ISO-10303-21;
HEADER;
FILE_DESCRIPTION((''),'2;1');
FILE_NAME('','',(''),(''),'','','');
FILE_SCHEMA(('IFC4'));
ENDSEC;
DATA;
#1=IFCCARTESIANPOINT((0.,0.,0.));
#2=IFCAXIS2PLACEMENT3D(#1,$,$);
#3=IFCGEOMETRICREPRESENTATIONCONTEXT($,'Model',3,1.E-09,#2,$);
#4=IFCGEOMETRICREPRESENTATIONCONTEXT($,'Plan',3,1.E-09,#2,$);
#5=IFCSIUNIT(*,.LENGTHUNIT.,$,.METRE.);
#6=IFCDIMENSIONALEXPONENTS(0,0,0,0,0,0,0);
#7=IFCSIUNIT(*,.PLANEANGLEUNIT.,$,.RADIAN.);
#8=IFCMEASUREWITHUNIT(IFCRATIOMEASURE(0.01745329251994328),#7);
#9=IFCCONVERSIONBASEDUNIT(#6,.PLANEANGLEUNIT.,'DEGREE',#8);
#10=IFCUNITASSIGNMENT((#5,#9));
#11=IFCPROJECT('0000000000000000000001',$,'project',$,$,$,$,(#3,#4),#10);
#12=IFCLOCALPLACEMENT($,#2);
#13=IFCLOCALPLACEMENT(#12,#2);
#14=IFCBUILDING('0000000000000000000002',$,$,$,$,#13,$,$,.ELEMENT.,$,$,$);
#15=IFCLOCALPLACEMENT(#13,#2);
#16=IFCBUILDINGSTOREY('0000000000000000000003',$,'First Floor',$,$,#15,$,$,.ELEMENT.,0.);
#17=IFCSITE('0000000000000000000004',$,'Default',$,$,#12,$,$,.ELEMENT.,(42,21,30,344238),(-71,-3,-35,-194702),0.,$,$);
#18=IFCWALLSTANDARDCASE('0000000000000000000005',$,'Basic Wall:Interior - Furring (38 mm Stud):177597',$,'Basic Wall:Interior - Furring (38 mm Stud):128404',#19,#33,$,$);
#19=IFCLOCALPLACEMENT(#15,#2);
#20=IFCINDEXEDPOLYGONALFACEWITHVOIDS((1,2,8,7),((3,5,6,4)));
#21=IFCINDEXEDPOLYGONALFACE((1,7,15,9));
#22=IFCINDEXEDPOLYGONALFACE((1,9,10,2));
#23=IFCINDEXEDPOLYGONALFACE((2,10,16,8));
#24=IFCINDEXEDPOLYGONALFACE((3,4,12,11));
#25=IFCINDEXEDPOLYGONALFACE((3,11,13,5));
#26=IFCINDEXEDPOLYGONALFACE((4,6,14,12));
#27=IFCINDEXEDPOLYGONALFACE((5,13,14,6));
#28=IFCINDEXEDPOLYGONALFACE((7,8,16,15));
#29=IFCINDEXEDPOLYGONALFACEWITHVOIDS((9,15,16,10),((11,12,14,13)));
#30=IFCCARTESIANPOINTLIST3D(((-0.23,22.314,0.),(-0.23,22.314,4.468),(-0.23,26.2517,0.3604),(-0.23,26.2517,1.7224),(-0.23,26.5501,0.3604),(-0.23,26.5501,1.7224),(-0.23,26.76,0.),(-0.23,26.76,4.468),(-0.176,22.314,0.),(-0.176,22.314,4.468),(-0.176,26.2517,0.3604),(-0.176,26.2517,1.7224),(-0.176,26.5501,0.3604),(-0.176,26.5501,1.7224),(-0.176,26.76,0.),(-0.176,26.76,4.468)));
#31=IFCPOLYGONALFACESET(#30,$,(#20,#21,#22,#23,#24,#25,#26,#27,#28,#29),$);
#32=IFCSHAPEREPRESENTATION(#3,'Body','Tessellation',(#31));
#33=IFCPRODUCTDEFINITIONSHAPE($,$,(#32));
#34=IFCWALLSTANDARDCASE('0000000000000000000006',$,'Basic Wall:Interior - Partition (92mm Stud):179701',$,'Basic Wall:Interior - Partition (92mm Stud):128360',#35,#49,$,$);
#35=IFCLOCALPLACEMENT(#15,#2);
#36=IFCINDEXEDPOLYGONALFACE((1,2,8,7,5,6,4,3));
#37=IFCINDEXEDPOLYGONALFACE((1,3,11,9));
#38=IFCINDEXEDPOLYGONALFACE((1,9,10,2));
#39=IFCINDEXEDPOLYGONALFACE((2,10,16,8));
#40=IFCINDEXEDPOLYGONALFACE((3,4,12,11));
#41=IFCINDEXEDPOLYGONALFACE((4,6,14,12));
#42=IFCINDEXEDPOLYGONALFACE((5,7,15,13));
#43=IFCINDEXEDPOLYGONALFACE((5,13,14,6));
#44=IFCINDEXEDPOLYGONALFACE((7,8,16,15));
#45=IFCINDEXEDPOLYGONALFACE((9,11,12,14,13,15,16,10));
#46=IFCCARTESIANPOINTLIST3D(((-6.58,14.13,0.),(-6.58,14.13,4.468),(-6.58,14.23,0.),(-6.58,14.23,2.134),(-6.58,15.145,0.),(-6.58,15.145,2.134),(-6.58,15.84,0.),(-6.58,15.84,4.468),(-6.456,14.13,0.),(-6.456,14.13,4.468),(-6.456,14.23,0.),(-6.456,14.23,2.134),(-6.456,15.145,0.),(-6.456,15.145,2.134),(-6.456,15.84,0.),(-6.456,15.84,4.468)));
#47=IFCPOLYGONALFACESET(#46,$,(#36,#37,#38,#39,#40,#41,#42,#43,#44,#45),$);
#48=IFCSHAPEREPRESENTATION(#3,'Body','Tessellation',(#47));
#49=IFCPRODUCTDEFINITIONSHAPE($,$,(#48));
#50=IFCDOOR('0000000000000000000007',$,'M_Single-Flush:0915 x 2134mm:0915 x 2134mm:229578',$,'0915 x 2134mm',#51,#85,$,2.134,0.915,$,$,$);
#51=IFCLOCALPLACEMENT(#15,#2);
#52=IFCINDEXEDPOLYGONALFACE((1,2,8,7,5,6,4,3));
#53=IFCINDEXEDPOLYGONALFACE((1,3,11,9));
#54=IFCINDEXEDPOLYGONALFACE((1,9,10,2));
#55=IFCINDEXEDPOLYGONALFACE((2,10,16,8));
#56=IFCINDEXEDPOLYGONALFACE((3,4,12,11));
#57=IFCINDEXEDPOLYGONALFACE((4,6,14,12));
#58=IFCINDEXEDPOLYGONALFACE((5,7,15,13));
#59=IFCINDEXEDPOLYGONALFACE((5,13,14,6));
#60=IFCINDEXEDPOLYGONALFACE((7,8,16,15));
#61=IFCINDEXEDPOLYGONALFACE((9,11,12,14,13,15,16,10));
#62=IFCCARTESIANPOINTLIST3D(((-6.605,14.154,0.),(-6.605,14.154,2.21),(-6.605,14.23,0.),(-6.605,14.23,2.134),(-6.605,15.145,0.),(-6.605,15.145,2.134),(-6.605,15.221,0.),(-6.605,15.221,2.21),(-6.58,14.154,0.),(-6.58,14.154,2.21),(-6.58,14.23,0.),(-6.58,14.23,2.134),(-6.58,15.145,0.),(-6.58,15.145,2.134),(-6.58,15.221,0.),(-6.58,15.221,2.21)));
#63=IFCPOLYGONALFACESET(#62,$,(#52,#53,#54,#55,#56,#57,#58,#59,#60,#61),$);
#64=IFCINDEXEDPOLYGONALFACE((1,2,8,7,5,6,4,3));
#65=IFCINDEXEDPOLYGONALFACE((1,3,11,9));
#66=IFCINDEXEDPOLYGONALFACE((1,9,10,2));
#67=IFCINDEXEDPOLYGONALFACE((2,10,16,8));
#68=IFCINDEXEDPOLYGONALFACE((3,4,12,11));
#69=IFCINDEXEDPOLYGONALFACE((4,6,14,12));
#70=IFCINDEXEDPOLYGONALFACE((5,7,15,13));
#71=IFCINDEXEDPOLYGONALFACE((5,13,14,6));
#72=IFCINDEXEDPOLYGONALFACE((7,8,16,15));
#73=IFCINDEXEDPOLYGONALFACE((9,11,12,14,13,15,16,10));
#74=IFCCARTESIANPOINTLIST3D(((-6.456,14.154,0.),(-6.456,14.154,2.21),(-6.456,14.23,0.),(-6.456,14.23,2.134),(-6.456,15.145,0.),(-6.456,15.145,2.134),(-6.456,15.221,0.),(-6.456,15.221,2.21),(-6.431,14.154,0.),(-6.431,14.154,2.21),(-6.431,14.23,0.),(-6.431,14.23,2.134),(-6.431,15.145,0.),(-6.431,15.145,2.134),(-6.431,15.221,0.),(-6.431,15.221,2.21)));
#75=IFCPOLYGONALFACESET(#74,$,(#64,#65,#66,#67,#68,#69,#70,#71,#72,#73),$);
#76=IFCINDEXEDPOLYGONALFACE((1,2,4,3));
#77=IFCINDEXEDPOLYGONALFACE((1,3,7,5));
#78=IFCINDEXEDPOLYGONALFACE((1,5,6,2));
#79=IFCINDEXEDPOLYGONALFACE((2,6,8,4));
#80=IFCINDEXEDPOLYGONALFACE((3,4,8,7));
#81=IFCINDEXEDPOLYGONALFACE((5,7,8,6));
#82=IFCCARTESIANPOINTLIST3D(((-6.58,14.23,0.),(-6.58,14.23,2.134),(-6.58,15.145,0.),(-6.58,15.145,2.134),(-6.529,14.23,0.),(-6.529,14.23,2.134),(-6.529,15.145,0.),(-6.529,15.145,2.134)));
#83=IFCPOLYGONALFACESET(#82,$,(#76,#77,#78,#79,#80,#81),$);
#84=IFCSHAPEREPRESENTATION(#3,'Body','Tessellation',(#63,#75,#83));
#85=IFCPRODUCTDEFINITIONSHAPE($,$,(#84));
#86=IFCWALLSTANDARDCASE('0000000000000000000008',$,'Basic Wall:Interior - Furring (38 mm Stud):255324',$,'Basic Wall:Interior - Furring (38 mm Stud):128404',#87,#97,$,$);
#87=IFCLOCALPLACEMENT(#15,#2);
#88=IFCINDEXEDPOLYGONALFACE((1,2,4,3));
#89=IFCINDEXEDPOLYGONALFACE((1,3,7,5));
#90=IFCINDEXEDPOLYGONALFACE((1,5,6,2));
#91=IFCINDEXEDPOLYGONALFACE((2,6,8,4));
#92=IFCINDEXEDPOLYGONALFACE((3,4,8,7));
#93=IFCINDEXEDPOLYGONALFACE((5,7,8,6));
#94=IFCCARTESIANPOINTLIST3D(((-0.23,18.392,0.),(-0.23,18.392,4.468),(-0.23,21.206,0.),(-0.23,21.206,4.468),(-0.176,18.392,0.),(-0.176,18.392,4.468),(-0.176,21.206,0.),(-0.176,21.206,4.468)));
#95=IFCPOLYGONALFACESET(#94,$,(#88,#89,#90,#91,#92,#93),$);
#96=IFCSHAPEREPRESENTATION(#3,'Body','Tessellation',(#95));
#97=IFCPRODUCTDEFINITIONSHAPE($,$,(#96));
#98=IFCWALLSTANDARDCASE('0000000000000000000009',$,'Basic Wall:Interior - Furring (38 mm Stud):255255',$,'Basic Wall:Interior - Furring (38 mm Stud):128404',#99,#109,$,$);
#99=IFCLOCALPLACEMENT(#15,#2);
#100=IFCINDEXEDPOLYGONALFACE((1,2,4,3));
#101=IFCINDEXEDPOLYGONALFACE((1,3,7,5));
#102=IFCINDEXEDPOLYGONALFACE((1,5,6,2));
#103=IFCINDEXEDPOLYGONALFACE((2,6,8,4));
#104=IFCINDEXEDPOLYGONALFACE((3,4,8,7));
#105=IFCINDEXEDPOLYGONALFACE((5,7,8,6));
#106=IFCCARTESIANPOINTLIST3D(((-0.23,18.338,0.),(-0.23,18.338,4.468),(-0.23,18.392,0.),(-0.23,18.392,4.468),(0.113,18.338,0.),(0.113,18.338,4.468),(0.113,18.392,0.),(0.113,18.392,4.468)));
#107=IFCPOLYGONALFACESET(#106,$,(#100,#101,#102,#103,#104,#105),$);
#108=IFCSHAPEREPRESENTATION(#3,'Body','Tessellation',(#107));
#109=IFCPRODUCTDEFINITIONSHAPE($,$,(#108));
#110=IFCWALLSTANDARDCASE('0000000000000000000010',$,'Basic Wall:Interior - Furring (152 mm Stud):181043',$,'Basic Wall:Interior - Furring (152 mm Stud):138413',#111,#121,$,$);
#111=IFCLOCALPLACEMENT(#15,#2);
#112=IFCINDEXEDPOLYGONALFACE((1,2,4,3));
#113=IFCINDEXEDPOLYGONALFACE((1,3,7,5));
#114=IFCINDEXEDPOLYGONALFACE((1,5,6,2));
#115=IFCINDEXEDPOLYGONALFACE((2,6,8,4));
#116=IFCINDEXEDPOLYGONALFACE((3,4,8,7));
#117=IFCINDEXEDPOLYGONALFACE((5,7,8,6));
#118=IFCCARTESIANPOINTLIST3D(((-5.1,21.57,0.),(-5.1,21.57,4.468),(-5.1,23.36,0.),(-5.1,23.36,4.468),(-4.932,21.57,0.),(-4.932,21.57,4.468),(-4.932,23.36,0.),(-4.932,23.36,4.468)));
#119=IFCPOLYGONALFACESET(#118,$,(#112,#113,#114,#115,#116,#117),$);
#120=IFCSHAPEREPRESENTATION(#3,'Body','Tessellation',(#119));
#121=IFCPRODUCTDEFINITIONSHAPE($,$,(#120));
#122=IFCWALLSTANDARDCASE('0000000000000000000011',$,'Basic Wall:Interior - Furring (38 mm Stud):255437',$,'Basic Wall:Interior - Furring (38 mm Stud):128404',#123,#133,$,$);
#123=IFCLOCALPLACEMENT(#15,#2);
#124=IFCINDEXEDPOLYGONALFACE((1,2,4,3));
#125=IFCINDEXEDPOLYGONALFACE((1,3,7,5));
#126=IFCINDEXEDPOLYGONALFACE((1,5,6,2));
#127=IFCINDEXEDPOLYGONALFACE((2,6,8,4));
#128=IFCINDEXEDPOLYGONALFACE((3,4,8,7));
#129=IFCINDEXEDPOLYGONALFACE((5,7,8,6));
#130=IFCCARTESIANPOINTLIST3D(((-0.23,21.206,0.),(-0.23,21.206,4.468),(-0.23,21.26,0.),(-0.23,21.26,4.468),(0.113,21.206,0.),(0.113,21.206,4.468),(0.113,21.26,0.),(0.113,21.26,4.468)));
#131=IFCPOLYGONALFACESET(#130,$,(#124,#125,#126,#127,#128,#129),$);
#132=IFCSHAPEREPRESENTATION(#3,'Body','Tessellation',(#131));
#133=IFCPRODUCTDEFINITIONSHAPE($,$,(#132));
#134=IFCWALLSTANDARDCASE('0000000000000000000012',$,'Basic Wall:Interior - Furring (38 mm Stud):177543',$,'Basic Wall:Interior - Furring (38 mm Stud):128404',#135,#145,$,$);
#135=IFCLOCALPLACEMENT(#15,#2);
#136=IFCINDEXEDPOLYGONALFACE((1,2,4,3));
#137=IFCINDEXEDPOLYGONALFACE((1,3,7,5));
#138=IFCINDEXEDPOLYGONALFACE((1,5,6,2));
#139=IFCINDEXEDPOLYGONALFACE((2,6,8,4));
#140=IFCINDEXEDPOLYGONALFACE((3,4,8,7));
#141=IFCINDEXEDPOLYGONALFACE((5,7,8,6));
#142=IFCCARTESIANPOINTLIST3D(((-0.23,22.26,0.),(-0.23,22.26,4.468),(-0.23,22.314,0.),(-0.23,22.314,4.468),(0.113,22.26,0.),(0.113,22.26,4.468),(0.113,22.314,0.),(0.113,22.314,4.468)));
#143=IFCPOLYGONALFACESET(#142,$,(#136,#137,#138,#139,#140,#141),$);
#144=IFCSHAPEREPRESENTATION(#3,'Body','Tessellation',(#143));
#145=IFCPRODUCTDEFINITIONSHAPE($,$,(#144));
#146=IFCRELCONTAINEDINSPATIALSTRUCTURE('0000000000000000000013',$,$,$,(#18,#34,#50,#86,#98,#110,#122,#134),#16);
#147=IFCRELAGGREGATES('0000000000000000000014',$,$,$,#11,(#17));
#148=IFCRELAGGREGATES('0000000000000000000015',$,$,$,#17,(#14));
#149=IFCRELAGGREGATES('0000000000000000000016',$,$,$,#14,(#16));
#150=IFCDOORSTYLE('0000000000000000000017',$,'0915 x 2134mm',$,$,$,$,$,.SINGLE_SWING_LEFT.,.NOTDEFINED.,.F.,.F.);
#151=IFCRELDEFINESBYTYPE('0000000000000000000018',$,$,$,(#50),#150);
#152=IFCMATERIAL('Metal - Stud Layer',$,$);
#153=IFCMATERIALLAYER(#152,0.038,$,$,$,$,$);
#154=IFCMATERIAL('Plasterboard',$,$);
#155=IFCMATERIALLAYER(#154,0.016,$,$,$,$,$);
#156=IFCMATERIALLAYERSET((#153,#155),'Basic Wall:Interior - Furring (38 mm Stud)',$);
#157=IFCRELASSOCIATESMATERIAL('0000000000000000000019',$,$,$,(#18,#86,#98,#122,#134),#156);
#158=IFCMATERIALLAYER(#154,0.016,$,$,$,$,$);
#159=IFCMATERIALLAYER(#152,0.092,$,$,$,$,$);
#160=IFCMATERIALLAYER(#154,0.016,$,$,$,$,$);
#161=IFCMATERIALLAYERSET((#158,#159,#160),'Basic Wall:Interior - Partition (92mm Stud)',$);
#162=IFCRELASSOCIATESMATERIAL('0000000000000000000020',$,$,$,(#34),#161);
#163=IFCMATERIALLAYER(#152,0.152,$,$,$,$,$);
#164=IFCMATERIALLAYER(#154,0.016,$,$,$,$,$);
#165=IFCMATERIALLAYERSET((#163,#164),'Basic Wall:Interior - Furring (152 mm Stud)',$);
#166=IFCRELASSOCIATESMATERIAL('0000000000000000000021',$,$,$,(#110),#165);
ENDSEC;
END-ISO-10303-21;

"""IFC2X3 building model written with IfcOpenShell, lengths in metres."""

from ifc_helpers import new_model, entity, si_unit, converted_unit, frame, frame_2d, origin, origin_2d_with_axis, place, context, project, spatial, polyline, rectangle, outline, extrude, source, transform, mapped, material, layer, layer_set, layer_usage, type_object, type_shapes, element, fill, save


model = new_model("IFC2X3")

# Units and contexts
model_context = context("Model", 3, precision=1e-09, world=origin())
plan_context = context("Plan", 3, precision=1e-09, world=origin())
ifc_project = project(units=[si_unit("LENGTHUNIT", "METRE"), converted_unit("PLANEANGLEUNIT", "DEGREE", entity("IfcRatioMeasure", 0.01745329251994328), si_unit("PLANEANGLEUNIT", "RADIAN"), dimensions=[0, 0, 0, 0, 0, 0, 0])], contexts=[model_context, plan_context])

# Site, building, storey
site_placement = place(None, origin())
site = spatial("IfcSite", under=ifc_project, at=site_placement, Name="Default", CompositionType="ELEMENT", RefLatitude=(42, 21, 30, 344238), RefLongitude=(-71, -3, -35, -194702), RefElevation=0.0)
building_placement = place(site_placement, origin())
building = spatial("IfcBuilding", under=site, at=building_placement, CompositionType="ELEMENT")
storey_placement = place(building_placement, origin())
storey = spatial("IfcBuildingStorey", under=building, at=storey_placement, Name="First Floor", CompositionType="ELEMENT", Elevation=0.0)

# Shared definitions
ifc_material_1 = material(Name="Plasterboard")
ifc_layer_1 = layer(ifc_material_1, 0.016)
ifc_material_2 = material(Name="Metal - Stud Layer")
ifc_layer_2 = layer(ifc_material_2, 0.092)
ifc_layer_3 = layer(ifc_material_1, 0.016)
ifc_layer_set_1 = layer_set([ifc_layer_1, ifc_layer_2, ifc_layer_3], Name="Basic Wall:Interior - Partition (92mm Stud)")
ifc_layer_usage_1 = layer_usage(ifc_layer_set_1, "AXIS2", "NEGATIVE", 0.062)

# Shared definitions
door_style_1 = type_object("IfcDoorStyle", Name="0915 x 2134mm", ConstructionType="NOTDEFINED", OperationType="SINGLE_SWING_LEFT", ParameterTakesPrecedence=False, Sizeable=False)
shared_shape_1 = source(origin(), model_context, "Body", "SweptSolid", [
    extrude(outline(polyline([(-0.5335, -1.124), (0.5335, -1.124), (0.5335, 1.086), (0.4575, 1.086), (0.4575, -1.048), (-0.4575, -1.048), (-0.4575, 1.086), (-0.5335, 1.086), (-0.5335, -1.124)])), frame((0.4575, 0.149, 1.086), z_axis=(0.0, -1.0, 0.0), x_axis=(-1.0, 0.0, 0.0)), (0.0, 0.0, 1.0), 0.025),
    extrude(outline(polyline([(-1.124, -0.5335), (1.086, -0.5335), (1.086, -0.4575), (-1.048, -0.4575), (-1.048, 0.4575), (1.086, 0.4575), (1.086, 0.5335), (-1.124, 0.5335), (-1.124, -0.5335)])), frame((0.4575, 0.0, 1.086), z_axis=(0.0, -1.0, 0.0), x_axis=(0.0, 0.0, -1.0)), (0.0, 0.0, 1.0), 0.025),
    extrude(rectangle(XDim=0.915, YDim=0.051, at=origin_2d_with_axis()), frame((0.4575, 0.0985, 0.0)), (0.0, 0.0, 1.0), 2.134),
])
type_shapes(door_style_1, [shared_shape_1])

# Wall, opening
ifc_layer_4 = layer(ifc_material_2, 0.038)
ifc_layer_5 = layer(ifc_material_1, 0.016)
ifc_layer_set_2 = layer_set([ifc_layer_4, ifc_layer_5], Name="Basic Wall:Interior - Furring (38 mm Stud)")
ifc_layer_usage_2 = layer_usage(ifc_layer_set_2, "AXIS2", "POSITIVE", -0.027)
wall_1_placement = place(storey_placement, frame((-0.203, 22.314, 0.0), z_axis=(0.0, 0.0, 1.0), x_axis=(0.0, 1.0, 0.0)))
wall_1 = element("IfcWallStandardCase", 1, at=wall_1_placement, inside=storey, material=ifc_layer_usage_2, Name="Basic Wall:Interior - Furring (38 mm Stud):177597", ObjectType="Basic Wall:Interior - Furring (38 mm Stud):128404", context=model_context, shape_type="SweptSolid", body=[
    extrude(rectangle(XDim=4.446, YDim=0.054, at=frame_2d((2.223, 0.0), x_axis=(-1.0, 0.0))), origin(), (0.0, 0.0, 1.0), 4.468),
])
opening_1_placement = place(wall_1_placement, origin())
element("IfcOpeningElement", 2, at=opening_1_placement, cuts=wall_1, ObjectType="Opening", context=model_context, shape_type="SweptSolid", body=[
    extrude(rectangle(XDim=1.3621, YDim=0.2985, at=frame_2d((0.0, 0.0), x_axis=(0.0, 1.0))), frame((4.0869, -0.0619, 1.0414), z_axis=(0.0, 1.0, 0.0), x_axis=(1.0, 0.0, 0.0)), (0.0, 0.0, 1.0), 0.1524),
])

# Wall, opening, door
wall_2_placement = place(storey_placement, frame((-6.518, 14.13, 0.0), z_axis=(0.0, 0.0, 1.0), x_axis=(0.0, 1.0, 0.0)))
wall_2 = element("IfcWallStandardCase", 3, at=wall_2_placement, inside=storey, material=ifc_layer_usage_1, Name="Basic Wall:Interior - Partition (92mm Stud):179701", ObjectType="Basic Wall:Interior - Partition (92mm Stud):128360", context=model_context, shape_type="SweptSolid", body=[
    extrude(rectangle(XDim=1.71, YDim=0.124, at=frame_2d((0.855, 0.0), x_axis=(-1.0, 0.0))), origin(), (0.0, 0.0, 1.0), 4.468),
])
opening_2_placement = place(wall_2_placement, frame((0.1, -0.062, 0.0)))
opening_2 = element("IfcOpeningElement", 4, at=opening_2_placement, cuts=wall_2, ObjectType="Opening", context=model_context, shape_type="SweptSolid", body=[
    extrude(rectangle(XDim=0.915, YDim=2.134, at=frame_2d((1.067, 0.4575), x_axis=(0.0, -1.0))), frame((0.0, 0.0, 0.0), z_axis=(0.0, 1.0, 0.0), x_axis=(0.0, 0.0, 1.0)), (0.0, 0.0, 1.0), 0.124),
])
door_1_placement = place(opening_2_placement, origin())
door_1 = element("IfcDoor", 5, at=door_1_placement, inside=storey, type_object=door_style_1, Name="M_Single-Flush:0915 x 2134mm:0915 x 2134mm:229578", ObjectType="0915 x 2134mm", OverallHeight=2.134, OverallWidth=0.915, context=model_context, shape_type="MappedRepresentation", body=[
    mapped(shared_shape_1, transform((0.0, 0.0, 0.0), scale=1.0)),
])
fill(opening_2, door_1)

# Walls
wall_3_placement = place(storey_placement, frame((-0.203, 18.392, 0.0), z_axis=(0.0, 0.0, 1.0), x_axis=(0.0, 1.0, 0.0)))
element("IfcWallStandardCase", 6, at=wall_3_placement, inside=storey, material=ifc_layer_usage_2, Name="Basic Wall:Interior - Furring (38 mm Stud):255324", ObjectType="Basic Wall:Interior - Furring (38 mm Stud):128404", context=model_context, shape_type="SweptSolid", body=[
    extrude(rectangle(XDim=2.814, YDim=0.054, at=frame_2d((1.407, 0.0), x_axis=(-1.0, 0.0))), origin(), (0.0, 0.0, 1.0), 4.468),
])
wall_4_placement = place(storey_placement, frame((0.113, 18.365, 0.0), z_axis=(0.0, 0.0, 1.0), x_axis=(-1.0, 0.0, 0.0)))
element("IfcWallStandardCase", 7, at=wall_4_placement, inside=storey, material=ifc_layer_usage_2, Name="Basic Wall:Interior - Furring (38 mm Stud):255255", ObjectType="Basic Wall:Interior - Furring (38 mm Stud):128404", context=model_context, shape_type="SweptSolid", body=[
    extrude(rectangle(XDim=0.343, YDim=0.054, at=frame_2d((0.1715, 0.0), x_axis=(-1.0, 0.0))), origin(), (0.0, 0.0, 1.0), 4.468),
])
ifc_layer_6 = layer(ifc_material_2, 0.152)
ifc_layer_7 = layer(ifc_material_1, 0.016)
ifc_layer_set_3 = layer_set([ifc_layer_6, ifc_layer_7], Name="Basic Wall:Interior - Furring (152 mm Stud)")
ifc_layer_usage_3 = layer_usage(ifc_layer_set_3, "AXIS2", "POSITIVE", -0.084)
wall_5_placement = place(storey_placement, frame((-5.016, 21.57, 0.0), z_axis=(0.0, 0.0, 1.0), x_axis=(0.0, 1.0, 0.0)))
element("IfcWallStandardCase", 8, at=wall_5_placement, inside=storey, material=ifc_layer_usage_3, Name="Basic Wall:Interior - Furring (152 mm Stud):181043", ObjectType="Basic Wall:Interior - Furring (152 mm Stud):138413", context=model_context, shape_type="SweptSolid", body=[
    extrude(rectangle(XDim=1.79, YDim=0.168, at=frame_2d((0.895, 0.0), x_axis=(-1.0, 0.0))), origin(), (0.0, 0.0, 1.0), 4.468),
])
wall_6_placement = place(storey_placement, frame((-0.23, 21.233, 0.0)))
element("IfcWallStandardCase", 9, at=wall_6_placement, inside=storey, material=ifc_layer_usage_2, Name="Basic Wall:Interior - Furring (38 mm Stud):255437", ObjectType="Basic Wall:Interior - Furring (38 mm Stud):128404", context=model_context, shape_type="SweptSolid", body=[
    extrude(rectangle(XDim=0.343, YDim=0.054, at=frame_2d((0.1715, 0.0), x_axis=(-1.0, 0.0))), origin(), (0.0, 0.0, 1.0), 4.468),
])
wall_7_placement = place(storey_placement, frame((0.113, 22.287, 0.0), z_axis=(0.0, 0.0, 1.0), x_axis=(-1.0, 0.0, 0.0)))
element("IfcWallStandardCase", 10, at=wall_7_placement, inside=storey, material=ifc_layer_usage_2, Name="Basic Wall:Interior - Furring (38 mm Stud):177543", ObjectType="Basic Wall:Interior - Furring (38 mm Stud):128404", context=model_context, shape_type="SweptSolid", body=[
    extrude(rectangle(XDim=0.343, YDim=0.054, at=frame_2d((0.1715, 0.0), x_axis=(-1.0, 0.0))), origin(), (0.0, 0.0, 1.0), 4.468),
])

save(model, "model.ifc")
